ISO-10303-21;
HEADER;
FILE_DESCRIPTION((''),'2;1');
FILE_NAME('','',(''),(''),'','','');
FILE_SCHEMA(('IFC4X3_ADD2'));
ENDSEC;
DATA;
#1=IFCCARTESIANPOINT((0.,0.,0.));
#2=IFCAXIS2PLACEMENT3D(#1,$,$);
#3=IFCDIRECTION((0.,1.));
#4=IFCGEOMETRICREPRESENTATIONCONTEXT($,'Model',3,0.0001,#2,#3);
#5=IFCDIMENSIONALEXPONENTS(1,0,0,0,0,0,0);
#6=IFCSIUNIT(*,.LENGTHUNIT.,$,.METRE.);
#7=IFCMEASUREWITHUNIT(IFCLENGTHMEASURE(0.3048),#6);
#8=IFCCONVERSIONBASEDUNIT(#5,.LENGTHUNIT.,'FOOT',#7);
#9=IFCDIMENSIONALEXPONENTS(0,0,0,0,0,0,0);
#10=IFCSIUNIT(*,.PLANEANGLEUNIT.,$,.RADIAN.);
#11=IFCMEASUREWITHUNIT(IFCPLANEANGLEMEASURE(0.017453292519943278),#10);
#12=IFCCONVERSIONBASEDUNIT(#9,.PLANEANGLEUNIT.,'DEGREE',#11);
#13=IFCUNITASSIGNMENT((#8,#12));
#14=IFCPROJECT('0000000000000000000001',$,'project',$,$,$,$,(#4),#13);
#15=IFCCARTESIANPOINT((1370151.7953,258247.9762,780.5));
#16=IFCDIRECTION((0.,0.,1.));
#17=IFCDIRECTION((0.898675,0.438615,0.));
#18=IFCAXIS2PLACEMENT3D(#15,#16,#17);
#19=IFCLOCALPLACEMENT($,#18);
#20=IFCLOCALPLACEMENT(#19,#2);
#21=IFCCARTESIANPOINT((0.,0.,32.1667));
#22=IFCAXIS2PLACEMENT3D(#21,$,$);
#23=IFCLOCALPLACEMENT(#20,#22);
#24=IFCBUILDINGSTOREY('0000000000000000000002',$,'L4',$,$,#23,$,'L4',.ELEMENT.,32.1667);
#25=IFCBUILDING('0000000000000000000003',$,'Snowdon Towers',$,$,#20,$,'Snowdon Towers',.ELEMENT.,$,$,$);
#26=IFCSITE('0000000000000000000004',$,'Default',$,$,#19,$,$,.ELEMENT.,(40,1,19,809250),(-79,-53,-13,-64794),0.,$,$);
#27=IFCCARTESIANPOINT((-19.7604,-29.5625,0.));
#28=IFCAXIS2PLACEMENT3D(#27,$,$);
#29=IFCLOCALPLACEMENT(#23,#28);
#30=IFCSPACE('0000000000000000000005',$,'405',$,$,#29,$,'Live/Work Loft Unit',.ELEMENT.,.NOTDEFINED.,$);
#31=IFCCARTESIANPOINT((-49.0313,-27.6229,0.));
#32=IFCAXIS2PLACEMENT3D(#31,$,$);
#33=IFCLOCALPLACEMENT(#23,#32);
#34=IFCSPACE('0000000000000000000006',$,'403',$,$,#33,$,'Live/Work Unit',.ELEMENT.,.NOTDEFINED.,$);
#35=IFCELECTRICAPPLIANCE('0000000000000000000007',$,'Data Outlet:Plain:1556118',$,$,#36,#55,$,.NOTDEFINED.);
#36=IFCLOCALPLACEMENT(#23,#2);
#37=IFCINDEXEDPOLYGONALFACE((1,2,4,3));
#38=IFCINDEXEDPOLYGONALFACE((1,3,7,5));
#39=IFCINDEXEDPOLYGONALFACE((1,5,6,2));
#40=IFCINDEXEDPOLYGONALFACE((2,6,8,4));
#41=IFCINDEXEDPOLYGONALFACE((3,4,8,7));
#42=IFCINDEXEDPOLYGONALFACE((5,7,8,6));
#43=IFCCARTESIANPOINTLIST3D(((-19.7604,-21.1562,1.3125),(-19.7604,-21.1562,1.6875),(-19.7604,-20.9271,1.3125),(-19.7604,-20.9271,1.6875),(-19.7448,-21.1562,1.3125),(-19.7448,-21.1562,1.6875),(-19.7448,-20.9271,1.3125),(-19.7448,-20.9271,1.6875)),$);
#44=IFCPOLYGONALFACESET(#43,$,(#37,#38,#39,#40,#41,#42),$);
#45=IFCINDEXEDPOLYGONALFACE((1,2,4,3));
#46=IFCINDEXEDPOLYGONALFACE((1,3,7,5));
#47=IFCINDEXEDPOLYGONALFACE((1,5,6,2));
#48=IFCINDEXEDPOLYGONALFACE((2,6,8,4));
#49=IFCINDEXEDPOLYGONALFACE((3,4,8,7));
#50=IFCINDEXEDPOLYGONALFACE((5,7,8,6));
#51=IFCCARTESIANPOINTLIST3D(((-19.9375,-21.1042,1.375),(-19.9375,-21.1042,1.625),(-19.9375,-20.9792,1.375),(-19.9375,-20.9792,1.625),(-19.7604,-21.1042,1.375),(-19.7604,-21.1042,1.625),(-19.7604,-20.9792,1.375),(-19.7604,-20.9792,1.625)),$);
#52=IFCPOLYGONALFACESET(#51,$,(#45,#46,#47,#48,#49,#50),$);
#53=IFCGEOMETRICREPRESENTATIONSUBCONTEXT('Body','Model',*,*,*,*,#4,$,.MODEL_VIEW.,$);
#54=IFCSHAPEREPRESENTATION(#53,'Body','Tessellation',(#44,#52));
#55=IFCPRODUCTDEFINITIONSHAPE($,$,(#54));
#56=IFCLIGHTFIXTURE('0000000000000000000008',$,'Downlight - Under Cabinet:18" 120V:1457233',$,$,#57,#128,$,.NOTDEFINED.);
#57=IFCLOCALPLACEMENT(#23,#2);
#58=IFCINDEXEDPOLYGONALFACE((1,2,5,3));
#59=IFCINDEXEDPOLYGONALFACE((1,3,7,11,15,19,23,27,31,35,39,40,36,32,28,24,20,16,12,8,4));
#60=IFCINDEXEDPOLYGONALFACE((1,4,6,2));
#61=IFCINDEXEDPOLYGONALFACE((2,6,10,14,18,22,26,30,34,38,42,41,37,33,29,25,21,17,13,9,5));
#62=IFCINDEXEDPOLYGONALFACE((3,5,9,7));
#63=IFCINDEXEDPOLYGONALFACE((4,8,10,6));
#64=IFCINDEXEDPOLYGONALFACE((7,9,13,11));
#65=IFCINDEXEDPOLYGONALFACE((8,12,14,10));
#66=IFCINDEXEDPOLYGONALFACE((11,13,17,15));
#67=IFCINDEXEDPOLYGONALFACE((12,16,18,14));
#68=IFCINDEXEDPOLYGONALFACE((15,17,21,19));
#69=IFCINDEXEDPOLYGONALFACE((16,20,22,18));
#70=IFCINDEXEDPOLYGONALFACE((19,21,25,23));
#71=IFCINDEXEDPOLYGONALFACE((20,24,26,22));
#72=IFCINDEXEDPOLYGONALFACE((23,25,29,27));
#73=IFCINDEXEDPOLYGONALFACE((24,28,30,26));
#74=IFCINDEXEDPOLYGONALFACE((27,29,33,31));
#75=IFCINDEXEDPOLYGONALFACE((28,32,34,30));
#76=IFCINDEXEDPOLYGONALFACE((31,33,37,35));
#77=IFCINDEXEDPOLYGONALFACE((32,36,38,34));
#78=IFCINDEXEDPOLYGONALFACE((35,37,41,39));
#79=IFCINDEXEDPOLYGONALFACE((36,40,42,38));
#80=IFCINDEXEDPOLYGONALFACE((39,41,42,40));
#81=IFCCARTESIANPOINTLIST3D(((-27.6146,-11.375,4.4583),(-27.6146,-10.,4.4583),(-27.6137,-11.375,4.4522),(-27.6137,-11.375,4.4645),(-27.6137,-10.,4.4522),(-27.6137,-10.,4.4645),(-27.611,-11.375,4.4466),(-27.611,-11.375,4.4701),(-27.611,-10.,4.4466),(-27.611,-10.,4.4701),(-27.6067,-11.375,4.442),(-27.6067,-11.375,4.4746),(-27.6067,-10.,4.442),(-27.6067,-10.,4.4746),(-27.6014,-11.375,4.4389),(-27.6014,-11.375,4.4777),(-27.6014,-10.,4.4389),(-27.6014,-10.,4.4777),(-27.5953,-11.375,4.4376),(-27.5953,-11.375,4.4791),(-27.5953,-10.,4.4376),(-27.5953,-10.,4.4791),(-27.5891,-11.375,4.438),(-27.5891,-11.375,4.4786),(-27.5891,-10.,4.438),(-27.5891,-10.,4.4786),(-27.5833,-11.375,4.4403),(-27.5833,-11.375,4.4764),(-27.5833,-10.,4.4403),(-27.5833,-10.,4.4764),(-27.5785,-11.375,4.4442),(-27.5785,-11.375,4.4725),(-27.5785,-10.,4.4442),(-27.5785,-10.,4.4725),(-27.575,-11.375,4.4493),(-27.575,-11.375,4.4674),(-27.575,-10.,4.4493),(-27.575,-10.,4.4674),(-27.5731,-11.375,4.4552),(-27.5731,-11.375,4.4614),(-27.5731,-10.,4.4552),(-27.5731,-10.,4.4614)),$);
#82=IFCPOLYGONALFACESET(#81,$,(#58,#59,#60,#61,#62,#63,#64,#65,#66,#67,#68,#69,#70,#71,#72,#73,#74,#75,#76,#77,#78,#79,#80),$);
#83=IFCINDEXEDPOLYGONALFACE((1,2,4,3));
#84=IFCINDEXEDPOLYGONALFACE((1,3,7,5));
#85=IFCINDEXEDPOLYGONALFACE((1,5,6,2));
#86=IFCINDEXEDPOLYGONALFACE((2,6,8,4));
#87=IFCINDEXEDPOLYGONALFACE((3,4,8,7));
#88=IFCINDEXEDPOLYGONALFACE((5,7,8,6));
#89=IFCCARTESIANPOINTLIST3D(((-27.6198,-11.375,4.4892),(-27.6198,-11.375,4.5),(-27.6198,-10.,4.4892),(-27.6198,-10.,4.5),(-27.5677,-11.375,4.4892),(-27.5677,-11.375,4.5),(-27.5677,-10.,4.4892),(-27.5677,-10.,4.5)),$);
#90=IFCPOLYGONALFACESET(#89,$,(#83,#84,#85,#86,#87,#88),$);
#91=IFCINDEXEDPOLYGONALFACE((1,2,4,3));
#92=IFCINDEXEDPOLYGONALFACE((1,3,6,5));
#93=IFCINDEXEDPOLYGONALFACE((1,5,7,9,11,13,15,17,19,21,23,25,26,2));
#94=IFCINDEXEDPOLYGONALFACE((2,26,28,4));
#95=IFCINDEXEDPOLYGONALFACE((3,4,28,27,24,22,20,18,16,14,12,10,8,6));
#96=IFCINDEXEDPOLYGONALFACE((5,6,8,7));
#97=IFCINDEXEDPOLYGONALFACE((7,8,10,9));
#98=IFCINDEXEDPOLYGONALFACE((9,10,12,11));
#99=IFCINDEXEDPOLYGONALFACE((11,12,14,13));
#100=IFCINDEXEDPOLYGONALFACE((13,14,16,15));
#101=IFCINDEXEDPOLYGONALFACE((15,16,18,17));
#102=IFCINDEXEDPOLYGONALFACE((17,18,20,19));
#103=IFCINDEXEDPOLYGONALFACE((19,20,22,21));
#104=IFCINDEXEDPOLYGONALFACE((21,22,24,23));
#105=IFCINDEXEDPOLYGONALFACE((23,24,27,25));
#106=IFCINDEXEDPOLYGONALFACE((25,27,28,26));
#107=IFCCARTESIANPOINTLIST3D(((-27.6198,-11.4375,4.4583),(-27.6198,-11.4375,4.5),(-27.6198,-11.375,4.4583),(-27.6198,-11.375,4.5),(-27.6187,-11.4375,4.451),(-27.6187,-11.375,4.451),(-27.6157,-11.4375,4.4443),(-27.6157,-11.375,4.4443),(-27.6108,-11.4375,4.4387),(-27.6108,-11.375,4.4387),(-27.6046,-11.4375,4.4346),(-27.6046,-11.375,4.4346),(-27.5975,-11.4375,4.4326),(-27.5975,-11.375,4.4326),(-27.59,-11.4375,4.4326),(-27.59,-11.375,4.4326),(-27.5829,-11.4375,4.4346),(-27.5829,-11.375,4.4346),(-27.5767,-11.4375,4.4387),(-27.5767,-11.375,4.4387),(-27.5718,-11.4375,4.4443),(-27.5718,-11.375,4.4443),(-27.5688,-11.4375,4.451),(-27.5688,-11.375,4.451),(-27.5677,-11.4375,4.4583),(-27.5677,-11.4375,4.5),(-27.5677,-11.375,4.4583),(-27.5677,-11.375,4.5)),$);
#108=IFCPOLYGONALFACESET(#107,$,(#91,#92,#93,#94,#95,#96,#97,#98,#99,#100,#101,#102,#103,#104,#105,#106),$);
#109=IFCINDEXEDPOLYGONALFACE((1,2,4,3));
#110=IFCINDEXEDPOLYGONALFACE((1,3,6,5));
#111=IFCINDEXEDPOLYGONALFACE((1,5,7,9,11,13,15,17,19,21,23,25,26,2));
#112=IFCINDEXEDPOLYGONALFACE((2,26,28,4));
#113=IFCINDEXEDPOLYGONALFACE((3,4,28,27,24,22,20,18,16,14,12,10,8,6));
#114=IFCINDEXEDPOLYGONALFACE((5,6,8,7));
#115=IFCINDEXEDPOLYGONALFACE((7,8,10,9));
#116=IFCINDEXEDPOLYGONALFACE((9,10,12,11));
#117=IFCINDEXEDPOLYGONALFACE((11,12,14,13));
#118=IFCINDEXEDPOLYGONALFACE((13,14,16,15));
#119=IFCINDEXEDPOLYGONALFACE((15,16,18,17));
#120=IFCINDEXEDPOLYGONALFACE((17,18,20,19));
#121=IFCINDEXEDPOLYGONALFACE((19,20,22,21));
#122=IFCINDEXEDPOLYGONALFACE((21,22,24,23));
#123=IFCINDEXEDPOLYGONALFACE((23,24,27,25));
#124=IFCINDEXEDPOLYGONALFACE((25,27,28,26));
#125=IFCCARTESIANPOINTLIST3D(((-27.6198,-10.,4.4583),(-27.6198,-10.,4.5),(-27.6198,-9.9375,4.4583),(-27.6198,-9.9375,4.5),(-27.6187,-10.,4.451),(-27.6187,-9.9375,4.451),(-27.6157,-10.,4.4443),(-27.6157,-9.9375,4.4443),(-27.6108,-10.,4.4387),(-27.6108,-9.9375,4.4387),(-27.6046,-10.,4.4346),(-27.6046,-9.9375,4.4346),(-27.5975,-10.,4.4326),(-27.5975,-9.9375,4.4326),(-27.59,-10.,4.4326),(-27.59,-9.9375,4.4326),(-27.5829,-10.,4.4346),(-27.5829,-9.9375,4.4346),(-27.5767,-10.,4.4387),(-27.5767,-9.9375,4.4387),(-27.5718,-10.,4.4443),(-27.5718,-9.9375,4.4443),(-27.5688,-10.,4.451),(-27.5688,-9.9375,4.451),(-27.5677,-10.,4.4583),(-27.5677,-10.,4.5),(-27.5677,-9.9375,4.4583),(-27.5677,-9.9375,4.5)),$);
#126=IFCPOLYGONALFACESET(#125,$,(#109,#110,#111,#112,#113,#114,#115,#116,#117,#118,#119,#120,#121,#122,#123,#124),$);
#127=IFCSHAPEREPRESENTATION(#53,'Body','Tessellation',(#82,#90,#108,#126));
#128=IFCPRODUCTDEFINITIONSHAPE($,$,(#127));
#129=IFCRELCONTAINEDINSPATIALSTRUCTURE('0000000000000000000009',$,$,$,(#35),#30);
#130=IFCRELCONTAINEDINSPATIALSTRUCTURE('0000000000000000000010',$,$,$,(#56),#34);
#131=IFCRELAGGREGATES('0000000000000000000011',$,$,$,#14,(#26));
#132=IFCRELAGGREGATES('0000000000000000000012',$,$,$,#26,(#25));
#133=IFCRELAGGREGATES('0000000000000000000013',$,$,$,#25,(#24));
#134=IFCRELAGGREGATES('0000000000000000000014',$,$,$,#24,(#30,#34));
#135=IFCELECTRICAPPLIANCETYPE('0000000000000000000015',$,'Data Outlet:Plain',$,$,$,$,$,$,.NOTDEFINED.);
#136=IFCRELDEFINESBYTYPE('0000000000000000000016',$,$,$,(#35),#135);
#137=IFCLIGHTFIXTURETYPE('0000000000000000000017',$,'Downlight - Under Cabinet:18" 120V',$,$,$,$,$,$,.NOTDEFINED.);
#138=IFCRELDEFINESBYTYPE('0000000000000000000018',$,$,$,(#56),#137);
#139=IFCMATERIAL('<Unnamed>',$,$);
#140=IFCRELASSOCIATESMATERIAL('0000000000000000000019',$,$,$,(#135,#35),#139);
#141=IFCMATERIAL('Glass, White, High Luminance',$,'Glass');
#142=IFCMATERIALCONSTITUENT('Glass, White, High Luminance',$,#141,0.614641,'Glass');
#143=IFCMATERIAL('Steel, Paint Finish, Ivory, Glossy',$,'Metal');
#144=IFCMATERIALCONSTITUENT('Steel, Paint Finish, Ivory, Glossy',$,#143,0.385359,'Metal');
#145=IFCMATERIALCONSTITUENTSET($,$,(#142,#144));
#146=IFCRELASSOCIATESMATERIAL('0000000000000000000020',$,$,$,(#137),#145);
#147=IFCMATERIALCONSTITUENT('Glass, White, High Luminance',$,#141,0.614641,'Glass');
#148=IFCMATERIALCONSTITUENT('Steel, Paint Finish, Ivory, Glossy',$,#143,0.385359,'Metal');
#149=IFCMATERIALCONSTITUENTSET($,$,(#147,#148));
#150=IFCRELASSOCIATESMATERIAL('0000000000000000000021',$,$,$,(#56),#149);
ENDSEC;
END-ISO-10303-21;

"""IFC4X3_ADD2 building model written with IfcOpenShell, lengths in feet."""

from ifc_helpers import new_model, entity, si_unit, converted_unit, direction, frame, frame_2d, origin, origin_2d_with_axis, place, context, subcontext, project, spatial, polyline, circle_curve, parameter, trimmed, segment, composite_curve, rectangle, circle, outline, extrude, source, transform, mapped, material, constituent, constituent_set, type_object, type_shapes, element, save


model = new_model("IFC4X3_ADD2")

# Units and contexts
model_context = context("Model", 3, precision=0.0001, world=origin(), true_north=direction((0.0, 1.0)))
body_context = subcontext(model_context, "Body", "Model", "MODEL_VIEW")
ifc_project = project(units=[converted_unit("LENGTHUNIT", "FOOT", entity("IfcLengthMeasure", 0.3048), si_unit("LENGTHUNIT", "METRE"), dimensions=[1, 0, 0, 0, 0, 0, 0]), converted_unit("PLANEANGLEUNIT", "DEGREE", entity("IfcPlaneAngleMeasure", 0.017453292519943278), si_unit("PLANEANGLEUNIT", "RADIAN"), dimensions=[0, 0, 0, 0, 0, 0, 0])], contexts=[model_context])

# Site, building, storey, space
site_placement = place(None, frame((1370151.7953, 258247.9762, 780.5), z_axis=(0.0, 0.0, 1.0), x_axis=(0.898675, 0.438615, 0.0)))
site = spatial("IfcSite", under=ifc_project, at=site_placement, Name="Default", CompositionType="ELEMENT", RefLatitude=(40, 1, 19, 809250), RefLongitude=(-79, -53, -13, -64794), RefElevation=0.0)
building_placement = place(site_placement, origin())
building = spatial("IfcBuilding", under=site, at=building_placement, Name="Snowdon Towers", LongName="Snowdon Towers", CompositionType="ELEMENT")
storey_placement = place(building_placement, frame((0.0, 0.0, 32.1667)))
storey = spatial("IfcBuildingStorey", under=building, at=storey_placement, Name="L4", LongName="L4", CompositionType="ELEMENT", Elevation=32.1667)
space_1_placement = place(storey_placement, frame((-19.7604, -29.5625, 0.0)))
space_1 = spatial("IfcSpace", under=storey, at=space_1_placement, Name="405", LongName="Live/Work Loft Unit", CompositionType="ELEMENT", PredefinedType="NOTDEFINED")

# Electric appliance
ifc_material_1 = material(Name="<Unnamed>")
electric_appliance_type = type_object("IfcElectricApplianceType", Name="Data Outlet:Plain", PredefinedType="NOTDEFINED", material=ifc_material_1)
shared_shape_1 = source(origin(), body_context, "Body", "SweptSolid", [
    extrude(rectangle(XDim=0.2292, YDim=0.375, at=frame_2d((0.0, 0.0), x_axis=(1.0, 0.0))), frame((0.0, 0.0, 0.0), z_axis=(0.0, 0.0, 1.0), x_axis=(-1.0, 0.0, 0.0)), (0.0, 0.0, 1.0), 0.0156),
    extrude(rectangle(XDim=0.125, YDim=0.25, at=frame_2d((0.0, 0.0), x_axis=(1.0, 0.0))), frame((0.0, 0.0, -0.1771), z_axis=(0.0, 0.0, 1.0), x_axis=(-1.0, 0.0, 0.0)), (0.0, 0.0, 1.0), 0.1771),
])
type_shapes(electric_appliance_type, [shared_shape_1])
electric_appliance_placement = place(space_1_placement, frame((0.0, 8.5208, 1.5), z_axis=(1.0, 0.0, 0.0), x_axis=(0.0, 1.0, 0.0)))
element("IfcElectricAppliance", 1, at=electric_appliance_placement, inside=space_1, type_object=electric_appliance_type, material=ifc_material_1, Name="Data Outlet:Plain:1556118", PredefinedType="NOTDEFINED", context=body_context, shape_type="MappedRepresentation", body=[
    mapped(shared_shape_1, transform((0.0, 0.0, 0.0), scale=1.0)),
])

# Shared definitions
space_2_placement = place(storey_placement, frame((-49.0313, -27.6229, 0.0)))
space_2 = spatial("IfcSpace", under=storey, at=space_2_placement, Name="403", LongName="Live/Work Unit", CompositionType="ELEMENT", PredefinedType="NOTDEFINED")

# Light fixture
ifc_material_2 = material(Name="Glass, White, High Luminance", Category="Glass")
ifc_constituent_1 = constituent(ifc_material_2, Name="Glass, White, High Luminance", Category="Glass", fraction=0.614641)
ifc_material_3 = material(Name="Steel, Paint Finish, Ivory, Glossy", Category="Metal")
ifc_constituent_2 = constituent(ifc_material_3, Name="Steel, Paint Finish, Ivory, Glossy", Category="Metal", fraction=0.385359)
ifc_constituent_set_1 = constituent_set(constituents=[ifc_constituent_1, ifc_constituent_2])
ifc_constituent_3 = constituent(ifc_material_2, Name="Glass, White, High Luminance", Category="Glass", fraction=0.614641)
ifc_constituent_4 = constituent(ifc_material_3, Name="Steel, Paint Finish, Ivory, Glossy", Category="Metal", fraction=0.385359)
ifc_constituent_set_2 = constituent_set(constituents=[ifc_constituent_3, ifc_constituent_4])
light_fixture_type_1 = type_object("IfcLightFixtureType", Name="Downlight - Under Cabinet:18\" 120V", PredefinedType="NOTDEFINED", material=ifc_constituent_set_2)
shared_shape_2 = source(origin(), body_context, "Body", "SweptSolid", [
    extrude(circle(Radius=0.0208, at=origin_2d_with_axis()), frame((-0.6875, 0.0, 4.4583), z_axis=(1.0, 0.0, 0.0), x_axis=(0.0, 1.0, 0.0)), (0.0, 0.0, 1.0), 1.375),
    extrude(rectangle(XDim=1.375, YDim=0.0521, at=origin_2d_with_axis()), frame((0.0, 0.0, 4.4892), z_axis=(0.0, 0.0, 1.0), x_axis=(-1.0, 0.0, 0.0)), (0.0, 0.0, 1.0), 0.0108),
    extrude(outline(composite_curve([segment(polyline([(-0.026, -0.0208), (0.026, -0.0208)]), True, "CONTINUOUS"), segment(polyline([(0.026, -0.0208), (0.026, 0.0208)]), True, "CONTINUOUS"), segment(trimmed(circle_curve(frame_2d((0.0, 0.0208), x_axis=(0.0, -1.0)), 0.026), [parameter(90.0)], [parameter(270.0)], True, "PARAMETER"), True, "CONTINUOUS"), segment(polyline([(-0.026, 0.0208), (-0.026, -0.0208)]), True, "CONTINUOUS")], self_intersect=False)), frame((-0.75, 0.0, 4.4792), z_axis=(1.0, 0.0, 0.0), x_axis=(0.0, -1.0, 0.0)), (0.0, 0.0, 1.0), 0.0625),
    extrude(outline(composite_curve([segment(polyline([(-0.0208, -0.026), (0.0208, -0.026)]), True, "CONTINUOUS"), segment(trimmed(circle_curve(frame_2d((0.0208, 0.0), x_axis=(0.0, 1.0)), 0.026), [parameter(180.0)], [parameter(360.0)], True, "PARAMETER"), True, "CONTINUOUS"), segment(polyline([(0.0208, 0.026), (-0.0208, 0.026)]), True, "CONTINUOUS"), segment(polyline([(-0.0208, 0.026), (-0.0208, -0.026)]), True, "CONTINUOUS")], self_intersect=False)), frame((0.6875, 0.0, 4.4792), z_axis=(1.0, 0.0, 0.0), x_axis=(0.0, 0.0, -1.0)), (0.0, 0.0, 1.0), 0.0625),
])
type_shapes(light_fixture_type_1, [shared_shape_2])
light_fixture_1_placement = place(space_2_placement, frame((21.4375, 16.9354, 0.0), z_axis=(0.0, 0.0, 1.0), x_axis=(0.0, 1.0, 0.0)))
element("IfcLightFixture", 2, at=light_fixture_1_placement, inside=space_2, type_object=light_fixture_type_1, material=ifc_constituent_set_1, Name="Downlight - Under Cabinet:18\" 120V:1457233", PredefinedType="NOTDEFINED", context=body_context, shape_type="MappedRepresentation", body=[
    mapped(shared_shape_2, transform((0.0, 0.0, 0.0), scale=1.0)),
])

save(model, "model.ifc")
